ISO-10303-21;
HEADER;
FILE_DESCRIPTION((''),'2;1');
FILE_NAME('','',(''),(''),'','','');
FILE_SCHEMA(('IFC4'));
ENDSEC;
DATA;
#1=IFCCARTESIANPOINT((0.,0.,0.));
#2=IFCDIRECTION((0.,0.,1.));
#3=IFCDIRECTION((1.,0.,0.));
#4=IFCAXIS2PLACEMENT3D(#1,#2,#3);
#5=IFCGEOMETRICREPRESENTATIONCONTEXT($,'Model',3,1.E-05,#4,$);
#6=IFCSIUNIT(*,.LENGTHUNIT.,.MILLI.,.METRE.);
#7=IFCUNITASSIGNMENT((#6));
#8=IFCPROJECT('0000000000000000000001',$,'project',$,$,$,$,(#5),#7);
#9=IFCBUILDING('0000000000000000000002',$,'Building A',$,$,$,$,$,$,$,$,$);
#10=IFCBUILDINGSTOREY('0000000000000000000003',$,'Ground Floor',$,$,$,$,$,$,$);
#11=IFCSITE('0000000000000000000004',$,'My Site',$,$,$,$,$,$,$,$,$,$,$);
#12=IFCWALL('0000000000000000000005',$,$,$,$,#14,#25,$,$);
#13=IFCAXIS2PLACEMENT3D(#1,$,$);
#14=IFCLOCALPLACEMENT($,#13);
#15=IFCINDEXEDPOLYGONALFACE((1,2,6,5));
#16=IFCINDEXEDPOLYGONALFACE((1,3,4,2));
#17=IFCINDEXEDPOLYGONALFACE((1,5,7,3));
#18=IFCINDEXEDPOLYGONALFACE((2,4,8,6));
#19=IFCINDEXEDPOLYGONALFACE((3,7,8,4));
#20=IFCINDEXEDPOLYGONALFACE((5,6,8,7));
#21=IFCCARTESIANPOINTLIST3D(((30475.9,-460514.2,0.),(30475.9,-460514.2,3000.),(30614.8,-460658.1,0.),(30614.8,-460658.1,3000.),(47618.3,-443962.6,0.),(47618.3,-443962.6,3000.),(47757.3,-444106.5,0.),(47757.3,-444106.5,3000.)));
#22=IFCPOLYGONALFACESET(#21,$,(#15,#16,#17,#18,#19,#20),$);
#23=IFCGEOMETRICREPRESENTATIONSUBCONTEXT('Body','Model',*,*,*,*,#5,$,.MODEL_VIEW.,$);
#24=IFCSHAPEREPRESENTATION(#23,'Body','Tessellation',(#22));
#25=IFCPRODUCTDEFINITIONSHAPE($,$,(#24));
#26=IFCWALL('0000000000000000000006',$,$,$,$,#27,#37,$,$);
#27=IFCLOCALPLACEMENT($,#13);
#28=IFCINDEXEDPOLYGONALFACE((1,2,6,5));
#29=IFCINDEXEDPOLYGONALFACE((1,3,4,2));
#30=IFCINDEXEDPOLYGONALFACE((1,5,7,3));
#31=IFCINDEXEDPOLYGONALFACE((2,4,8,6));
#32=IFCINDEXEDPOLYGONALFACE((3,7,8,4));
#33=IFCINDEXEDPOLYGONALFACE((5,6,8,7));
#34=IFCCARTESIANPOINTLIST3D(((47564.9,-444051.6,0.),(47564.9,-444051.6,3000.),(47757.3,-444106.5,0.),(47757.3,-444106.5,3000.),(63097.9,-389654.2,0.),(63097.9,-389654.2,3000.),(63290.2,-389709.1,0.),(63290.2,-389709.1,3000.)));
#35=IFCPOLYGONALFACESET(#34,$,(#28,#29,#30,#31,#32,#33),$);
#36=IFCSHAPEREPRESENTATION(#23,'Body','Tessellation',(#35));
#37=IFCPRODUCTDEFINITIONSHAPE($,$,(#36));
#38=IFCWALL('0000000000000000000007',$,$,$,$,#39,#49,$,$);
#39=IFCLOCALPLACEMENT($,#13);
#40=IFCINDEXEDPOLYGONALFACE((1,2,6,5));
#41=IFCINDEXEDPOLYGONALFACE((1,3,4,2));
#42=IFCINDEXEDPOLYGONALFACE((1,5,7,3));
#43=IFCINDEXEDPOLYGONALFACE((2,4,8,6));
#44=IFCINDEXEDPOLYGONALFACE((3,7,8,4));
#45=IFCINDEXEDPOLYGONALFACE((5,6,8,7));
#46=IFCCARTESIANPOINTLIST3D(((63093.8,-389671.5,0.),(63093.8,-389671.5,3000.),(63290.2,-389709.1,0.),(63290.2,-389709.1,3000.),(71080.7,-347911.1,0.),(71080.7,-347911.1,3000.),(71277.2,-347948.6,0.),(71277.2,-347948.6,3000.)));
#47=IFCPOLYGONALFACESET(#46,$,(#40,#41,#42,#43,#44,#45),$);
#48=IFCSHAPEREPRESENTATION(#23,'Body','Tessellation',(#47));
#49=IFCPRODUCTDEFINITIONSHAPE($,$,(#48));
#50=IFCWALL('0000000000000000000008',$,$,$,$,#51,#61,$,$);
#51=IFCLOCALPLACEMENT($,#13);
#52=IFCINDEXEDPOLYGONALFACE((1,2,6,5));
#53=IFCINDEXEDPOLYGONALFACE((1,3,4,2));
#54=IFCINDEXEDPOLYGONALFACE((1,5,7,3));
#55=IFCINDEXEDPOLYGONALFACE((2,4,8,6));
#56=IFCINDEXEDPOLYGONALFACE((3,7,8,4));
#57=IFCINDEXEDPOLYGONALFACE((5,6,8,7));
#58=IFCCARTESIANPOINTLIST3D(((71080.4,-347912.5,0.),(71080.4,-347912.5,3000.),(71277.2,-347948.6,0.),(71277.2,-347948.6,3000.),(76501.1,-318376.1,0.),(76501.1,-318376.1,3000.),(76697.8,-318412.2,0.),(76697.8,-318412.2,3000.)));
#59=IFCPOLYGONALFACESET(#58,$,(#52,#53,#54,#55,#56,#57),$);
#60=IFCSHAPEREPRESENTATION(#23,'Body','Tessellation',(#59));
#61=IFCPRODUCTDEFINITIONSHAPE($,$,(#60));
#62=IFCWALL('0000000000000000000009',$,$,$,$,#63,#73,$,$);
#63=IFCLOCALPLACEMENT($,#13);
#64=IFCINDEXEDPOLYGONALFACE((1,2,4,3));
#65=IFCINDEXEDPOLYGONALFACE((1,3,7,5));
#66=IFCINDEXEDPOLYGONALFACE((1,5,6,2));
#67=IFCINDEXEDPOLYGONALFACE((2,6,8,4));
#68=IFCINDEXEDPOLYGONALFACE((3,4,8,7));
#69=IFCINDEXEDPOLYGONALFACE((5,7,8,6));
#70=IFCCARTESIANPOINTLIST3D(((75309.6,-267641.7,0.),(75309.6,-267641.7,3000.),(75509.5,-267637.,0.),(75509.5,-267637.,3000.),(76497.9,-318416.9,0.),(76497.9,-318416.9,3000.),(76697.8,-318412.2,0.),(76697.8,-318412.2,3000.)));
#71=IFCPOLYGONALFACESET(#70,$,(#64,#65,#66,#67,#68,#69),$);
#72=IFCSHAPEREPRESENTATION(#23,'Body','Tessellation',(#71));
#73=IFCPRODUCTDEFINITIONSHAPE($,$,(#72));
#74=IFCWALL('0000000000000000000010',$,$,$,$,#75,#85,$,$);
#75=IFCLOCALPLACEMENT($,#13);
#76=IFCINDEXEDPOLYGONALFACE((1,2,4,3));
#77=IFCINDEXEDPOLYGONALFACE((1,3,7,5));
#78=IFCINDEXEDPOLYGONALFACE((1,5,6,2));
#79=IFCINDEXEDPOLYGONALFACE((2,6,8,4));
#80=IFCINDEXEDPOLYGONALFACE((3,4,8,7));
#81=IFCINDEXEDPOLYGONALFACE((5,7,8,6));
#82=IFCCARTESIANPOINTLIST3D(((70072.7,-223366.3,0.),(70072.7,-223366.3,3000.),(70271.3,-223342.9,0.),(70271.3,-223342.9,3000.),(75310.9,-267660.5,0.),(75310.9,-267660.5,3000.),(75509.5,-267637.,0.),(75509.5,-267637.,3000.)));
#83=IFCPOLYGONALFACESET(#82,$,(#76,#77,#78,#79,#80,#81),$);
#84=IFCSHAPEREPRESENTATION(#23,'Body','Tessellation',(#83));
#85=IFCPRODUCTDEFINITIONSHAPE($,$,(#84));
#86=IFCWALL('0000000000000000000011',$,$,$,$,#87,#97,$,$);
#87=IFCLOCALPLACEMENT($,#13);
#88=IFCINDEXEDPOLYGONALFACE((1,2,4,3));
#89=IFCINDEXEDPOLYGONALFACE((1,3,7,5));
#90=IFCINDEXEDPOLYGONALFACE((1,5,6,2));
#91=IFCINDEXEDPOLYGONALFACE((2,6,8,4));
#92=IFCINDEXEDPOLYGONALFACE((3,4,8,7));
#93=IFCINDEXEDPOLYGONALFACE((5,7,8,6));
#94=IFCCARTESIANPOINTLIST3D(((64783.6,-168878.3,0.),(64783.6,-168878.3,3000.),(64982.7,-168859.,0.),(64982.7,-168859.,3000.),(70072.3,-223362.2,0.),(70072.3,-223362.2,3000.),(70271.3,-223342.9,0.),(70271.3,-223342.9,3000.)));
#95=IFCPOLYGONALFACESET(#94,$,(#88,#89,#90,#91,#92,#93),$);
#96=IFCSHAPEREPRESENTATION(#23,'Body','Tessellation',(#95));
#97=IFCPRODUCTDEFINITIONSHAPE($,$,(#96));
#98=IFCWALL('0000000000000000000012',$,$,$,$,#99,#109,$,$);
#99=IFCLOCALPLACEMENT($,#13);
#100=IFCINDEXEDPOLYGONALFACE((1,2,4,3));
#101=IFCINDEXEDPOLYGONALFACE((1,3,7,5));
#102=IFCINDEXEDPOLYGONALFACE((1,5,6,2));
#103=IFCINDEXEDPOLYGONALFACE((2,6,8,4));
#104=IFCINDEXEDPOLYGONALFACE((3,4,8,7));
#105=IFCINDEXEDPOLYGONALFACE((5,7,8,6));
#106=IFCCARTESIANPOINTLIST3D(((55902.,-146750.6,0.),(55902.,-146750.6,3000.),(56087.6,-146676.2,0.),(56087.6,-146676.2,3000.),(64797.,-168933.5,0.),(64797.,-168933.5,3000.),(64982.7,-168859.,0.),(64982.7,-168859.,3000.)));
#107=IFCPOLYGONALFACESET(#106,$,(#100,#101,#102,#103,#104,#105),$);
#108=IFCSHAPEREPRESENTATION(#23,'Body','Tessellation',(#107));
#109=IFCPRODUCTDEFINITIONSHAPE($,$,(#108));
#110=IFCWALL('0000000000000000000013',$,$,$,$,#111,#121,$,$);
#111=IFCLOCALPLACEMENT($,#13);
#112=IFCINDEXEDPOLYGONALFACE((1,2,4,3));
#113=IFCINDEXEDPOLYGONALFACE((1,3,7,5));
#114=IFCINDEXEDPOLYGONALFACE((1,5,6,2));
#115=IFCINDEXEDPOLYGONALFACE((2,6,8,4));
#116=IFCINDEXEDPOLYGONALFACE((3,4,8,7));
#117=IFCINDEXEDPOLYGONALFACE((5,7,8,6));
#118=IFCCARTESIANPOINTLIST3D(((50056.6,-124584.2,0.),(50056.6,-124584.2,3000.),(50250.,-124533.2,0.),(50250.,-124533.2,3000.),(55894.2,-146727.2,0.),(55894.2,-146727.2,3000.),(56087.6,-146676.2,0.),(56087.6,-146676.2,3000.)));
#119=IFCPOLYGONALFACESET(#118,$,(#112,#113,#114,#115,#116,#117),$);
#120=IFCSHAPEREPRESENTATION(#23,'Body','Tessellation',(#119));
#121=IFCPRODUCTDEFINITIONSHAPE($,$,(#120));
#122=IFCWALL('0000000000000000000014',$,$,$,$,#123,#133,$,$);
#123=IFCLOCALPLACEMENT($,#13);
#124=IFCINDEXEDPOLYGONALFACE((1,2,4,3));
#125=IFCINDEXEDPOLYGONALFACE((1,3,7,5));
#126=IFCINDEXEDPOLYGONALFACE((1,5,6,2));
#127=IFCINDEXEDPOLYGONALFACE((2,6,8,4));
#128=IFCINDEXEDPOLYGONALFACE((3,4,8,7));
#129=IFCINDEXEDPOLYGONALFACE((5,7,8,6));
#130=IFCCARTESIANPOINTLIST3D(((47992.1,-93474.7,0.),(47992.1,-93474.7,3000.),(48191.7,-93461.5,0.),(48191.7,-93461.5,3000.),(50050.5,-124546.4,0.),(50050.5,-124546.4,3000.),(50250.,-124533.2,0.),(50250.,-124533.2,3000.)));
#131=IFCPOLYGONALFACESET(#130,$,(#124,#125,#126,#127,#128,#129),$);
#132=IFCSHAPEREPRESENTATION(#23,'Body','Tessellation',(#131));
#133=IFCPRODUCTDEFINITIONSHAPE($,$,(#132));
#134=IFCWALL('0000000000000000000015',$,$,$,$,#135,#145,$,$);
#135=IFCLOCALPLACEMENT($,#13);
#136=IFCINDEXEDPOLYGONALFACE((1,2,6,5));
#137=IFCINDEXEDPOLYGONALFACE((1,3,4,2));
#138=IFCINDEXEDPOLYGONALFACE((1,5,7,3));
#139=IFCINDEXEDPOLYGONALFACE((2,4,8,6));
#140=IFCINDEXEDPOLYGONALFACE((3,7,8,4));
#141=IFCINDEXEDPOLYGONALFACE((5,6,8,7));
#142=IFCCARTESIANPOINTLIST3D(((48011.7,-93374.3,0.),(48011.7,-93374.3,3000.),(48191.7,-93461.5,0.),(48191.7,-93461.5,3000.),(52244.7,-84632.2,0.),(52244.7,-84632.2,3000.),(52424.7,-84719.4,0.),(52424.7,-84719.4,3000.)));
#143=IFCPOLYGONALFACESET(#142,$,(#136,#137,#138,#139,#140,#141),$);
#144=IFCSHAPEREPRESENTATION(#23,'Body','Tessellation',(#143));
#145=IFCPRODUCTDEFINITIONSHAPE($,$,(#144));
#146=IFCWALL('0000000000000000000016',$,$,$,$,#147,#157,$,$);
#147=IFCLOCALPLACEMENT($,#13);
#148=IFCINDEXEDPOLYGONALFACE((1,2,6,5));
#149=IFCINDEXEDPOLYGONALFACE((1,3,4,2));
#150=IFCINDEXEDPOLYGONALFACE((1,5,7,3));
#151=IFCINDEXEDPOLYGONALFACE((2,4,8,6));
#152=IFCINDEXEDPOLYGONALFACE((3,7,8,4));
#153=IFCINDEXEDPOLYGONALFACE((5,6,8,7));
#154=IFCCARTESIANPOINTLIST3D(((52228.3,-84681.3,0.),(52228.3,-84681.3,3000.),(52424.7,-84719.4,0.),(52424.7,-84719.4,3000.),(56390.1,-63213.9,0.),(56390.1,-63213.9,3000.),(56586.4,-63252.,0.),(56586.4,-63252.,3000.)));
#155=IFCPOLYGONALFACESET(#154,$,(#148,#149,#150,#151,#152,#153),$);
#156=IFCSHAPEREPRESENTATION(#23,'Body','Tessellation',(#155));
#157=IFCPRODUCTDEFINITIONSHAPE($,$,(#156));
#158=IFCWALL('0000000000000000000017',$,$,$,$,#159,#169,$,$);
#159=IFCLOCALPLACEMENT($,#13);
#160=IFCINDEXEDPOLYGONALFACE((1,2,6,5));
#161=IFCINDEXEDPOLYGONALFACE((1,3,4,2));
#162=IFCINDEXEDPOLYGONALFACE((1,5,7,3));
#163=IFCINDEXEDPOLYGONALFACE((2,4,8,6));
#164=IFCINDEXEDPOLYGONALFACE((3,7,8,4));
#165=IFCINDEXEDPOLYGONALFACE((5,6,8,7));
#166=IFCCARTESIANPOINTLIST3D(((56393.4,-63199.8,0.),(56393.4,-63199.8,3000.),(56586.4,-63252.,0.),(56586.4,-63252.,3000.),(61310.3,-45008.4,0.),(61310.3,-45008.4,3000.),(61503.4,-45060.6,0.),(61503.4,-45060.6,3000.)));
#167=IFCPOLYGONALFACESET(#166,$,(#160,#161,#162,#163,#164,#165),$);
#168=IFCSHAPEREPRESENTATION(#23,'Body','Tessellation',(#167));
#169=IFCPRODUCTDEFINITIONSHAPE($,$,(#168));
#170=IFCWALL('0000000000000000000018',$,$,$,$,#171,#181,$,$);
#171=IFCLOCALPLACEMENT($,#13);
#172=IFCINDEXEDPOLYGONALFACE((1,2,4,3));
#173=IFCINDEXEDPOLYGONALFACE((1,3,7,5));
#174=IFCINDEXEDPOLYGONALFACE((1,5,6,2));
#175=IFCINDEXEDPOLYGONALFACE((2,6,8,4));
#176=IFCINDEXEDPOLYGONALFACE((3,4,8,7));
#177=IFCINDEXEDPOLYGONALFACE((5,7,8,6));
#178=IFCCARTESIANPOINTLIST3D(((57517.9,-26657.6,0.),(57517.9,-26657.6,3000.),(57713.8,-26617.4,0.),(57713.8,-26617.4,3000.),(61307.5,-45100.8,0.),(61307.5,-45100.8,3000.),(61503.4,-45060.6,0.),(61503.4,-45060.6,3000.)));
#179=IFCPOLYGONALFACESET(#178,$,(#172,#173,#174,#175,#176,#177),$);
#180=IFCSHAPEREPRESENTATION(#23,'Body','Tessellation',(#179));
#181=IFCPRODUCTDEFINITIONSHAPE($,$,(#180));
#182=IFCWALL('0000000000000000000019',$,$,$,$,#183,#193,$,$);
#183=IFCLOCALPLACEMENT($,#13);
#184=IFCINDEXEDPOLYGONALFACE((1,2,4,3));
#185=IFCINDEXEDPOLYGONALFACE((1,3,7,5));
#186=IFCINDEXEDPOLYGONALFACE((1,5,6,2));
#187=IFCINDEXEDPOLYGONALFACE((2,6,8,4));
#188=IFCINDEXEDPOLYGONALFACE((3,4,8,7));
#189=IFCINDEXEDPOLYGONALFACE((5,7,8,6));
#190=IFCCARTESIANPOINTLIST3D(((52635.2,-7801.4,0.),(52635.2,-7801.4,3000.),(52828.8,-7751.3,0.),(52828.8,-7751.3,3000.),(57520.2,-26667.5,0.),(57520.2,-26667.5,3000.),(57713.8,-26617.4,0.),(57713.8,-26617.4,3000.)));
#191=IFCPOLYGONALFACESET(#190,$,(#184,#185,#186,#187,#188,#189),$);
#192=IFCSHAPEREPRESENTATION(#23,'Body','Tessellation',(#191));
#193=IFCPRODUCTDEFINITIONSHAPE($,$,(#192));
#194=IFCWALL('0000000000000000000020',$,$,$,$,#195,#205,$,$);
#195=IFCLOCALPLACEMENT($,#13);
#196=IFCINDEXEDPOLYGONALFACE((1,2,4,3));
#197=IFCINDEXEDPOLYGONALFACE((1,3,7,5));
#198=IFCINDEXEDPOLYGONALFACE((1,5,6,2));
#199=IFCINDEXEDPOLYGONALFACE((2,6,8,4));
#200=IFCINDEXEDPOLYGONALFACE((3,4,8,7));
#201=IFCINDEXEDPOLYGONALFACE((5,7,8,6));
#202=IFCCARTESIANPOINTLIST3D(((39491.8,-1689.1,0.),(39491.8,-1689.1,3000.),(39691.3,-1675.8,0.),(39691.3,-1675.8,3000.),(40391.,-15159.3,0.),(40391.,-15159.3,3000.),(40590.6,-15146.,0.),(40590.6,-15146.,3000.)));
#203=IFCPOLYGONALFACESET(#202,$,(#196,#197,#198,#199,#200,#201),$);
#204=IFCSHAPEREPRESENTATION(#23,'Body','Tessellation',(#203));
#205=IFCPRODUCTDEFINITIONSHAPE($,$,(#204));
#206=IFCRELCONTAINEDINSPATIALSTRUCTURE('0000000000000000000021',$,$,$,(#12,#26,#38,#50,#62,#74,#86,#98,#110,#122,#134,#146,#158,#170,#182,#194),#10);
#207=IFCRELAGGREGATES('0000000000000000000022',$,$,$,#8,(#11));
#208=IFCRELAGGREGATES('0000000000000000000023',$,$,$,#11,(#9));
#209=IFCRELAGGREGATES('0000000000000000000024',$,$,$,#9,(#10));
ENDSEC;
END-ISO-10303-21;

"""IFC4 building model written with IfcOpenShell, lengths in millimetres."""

from ifc_helpers import new_model, si_unit, frame, origin_with_axes, place, context, subcontext, project, spatial, indexed_curve, outline, extrude, element, save


model = new_model("IFC4")

# Units and contexts
model_context = context("Model", 3, precision=1e-05, world=origin_with_axes())
body_context = subcontext(model_context, "Body", "Model", "MODEL_VIEW")
ifc_project = project(units=[si_unit("LENGTHUNIT", "METRE", prefix="MILLI")], contexts=[model_context])

# Site, building, storey
site = spatial("IfcSite", under=ifc_project, Name="My Site")
building = spatial("IfcBuilding", under=site, Name="Building A")
storey = spatial("IfcBuildingStorey", under=building, Name="Ground Floor")

# Walls
wall_1_placement = place(None, frame((30614.8, -460658.1, 0.0), z_axis=(0.0, 0.0, 1.0), x_axis=(0.719396, 0.694601, 0.0)))
element("IfcWall", 1, at=wall_1_placement, inside=storey, context=body_context, shape_type="SweptSolid", body=[
    extrude(outline(indexed_curve([(0.0, 0.0), (0.0, 200.0), (23828.9, 200.0), (23828.9, 0.0), (0.0, 0.0)], self_intersect=False)), origin_with_axes(), (0.0, 0.0, 1.0), 3000.0),
])
wall_2_placement = place(None, frame((47757.3, -444106.5, 0.0), z_axis=(0.0, 0.0, 1.0), x_axis=(0.274571, 0.961567, 0.0)))
element("IfcWall", 2, at=wall_2_placement, inside=storey, context=body_context, shape_type="SweptSolid", body=[
    extrude(outline(indexed_curve([(0.0, 0.0), (0.0, 200.0), (56571.7, 200.0), (56571.7, 0.0), (0.0, 0.0)], self_intersect=False)), origin_with_axes(), (0.0, 0.0, 1.0), 3000.0),
])
wall_3_placement = place(None, frame((63290.2, -389709.1, 0.0), z_axis=(0.0, 0.0, 1.0), x_axis=(0.187851, 0.982197, 0.0)))
element("IfcWall", 3, at=wall_3_placement, inside=storey, context=body_context, shape_type="SweptSolid", body=[
    extrude(outline(indexed_curve([(0.0, 0.0), (0.0, 200.0), (42517.4, 200.0), (42517.4, 0.0), (0.0, 0.0)], self_intersect=False)), origin_with_axes(), (0.0, 0.0, 1.0), 3000.0),
])
wall_4_placement = place(None, frame((71277.2, -347948.6, 0.0), z_axis=(0.0, 0.0, 1.0), x_axis=(0.18051, 0.983573, 0.0)))
element("IfcWall", 4, at=wall_4_placement, inside=storey, context=body_context, shape_type="SweptSolid", body=[
    extrude(outline(indexed_curve([(0.0, 0.0), (0.0, 200.0), (30029.7, 200.0), (30029.7, 0.0), (0.0, 0.0)], self_intersect=False)), origin_with_axes(), (0.0, 0.0, 1.0), 3000.0),
])
wall_5_placement = place(None, frame((76697.8, -318412.2, 0.0), z_axis=(0.0, 0.0, 1.0), x_axis=(-0.023397, 0.999726, 0.0)))
element("IfcWall", 5, at=wall_5_placement, inside=storey, context=body_context, shape_type="SweptSolid", body=[
    extrude(outline(indexed_curve([(0.0, 0.0), (0.0, 200.0), (50789.1, 200.0), (50789.1, 0.0), (0.0, 0.0)], self_intersect=False)), origin_with_axes(), (0.0, 0.0, 1.0), 3000.0),
])
wall_6_placement = place(None, frame((75509.5, -267637.0, 0.0), z_axis=(0.0, 0.0, 1.0), x_axis=(-0.11744, 0.99308, 0.0)))
element("IfcWall", 6, at=wall_6_placement, inside=storey, context=body_context, shape_type="SweptSolid", body=[
    extrude(outline(indexed_curve([(0.0, 0.0), (0.0, 200.0), (44602.8, 200.0), (44602.8, 0.0), (0.0, 0.0)], self_intersect=False)), origin_with_axes(), (0.0, 0.0, 1.0), 3000.0),
])
wall_7_placement = place(None, frame((70271.3, -223342.9, 0.0), z_axis=(0.0, 0.0, 1.0), x_axis=(-0.096615, 0.995322, 0.0)))
element("IfcWall", 7, at=wall_7_placement, inside=storey, context=body_context, shape_type="SweptSolid", body=[
    extrude(outline(indexed_curve([(0.0, 0.0), (0.0, 200.0), (54739.9, 200.0), (54739.9, 0.0), (0.0, 0.0)], self_intersect=False)), origin_with_axes(), (0.0, 0.0, 1.0), 3000.0),
])
wall_8_placement = place(None, frame((64982.7, -168859.0, 0.0), z_axis=(0.0, 0.0, 1.0), x_axis=(-0.372182, 0.92816, 0.0)))
element("IfcWall", 8, at=wall_8_placement, inside=storey, context=body_context, shape_type="SweptSolid", body=[
    extrude(outline(indexed_curve([(0.0, 0.0), (0.0, 200.0), (23899.8, 200.0), (23899.8, 0.0), (0.0, 0.0)], self_intersect=False)), origin_with_axes(), (0.0, 0.0, 1.0), 3000.0),
])
wall_9_placement = place(None, frame((56087.6, -146676.2, 0.0), z_axis=(0.0, 0.0, 1.0), x_axis=(-0.254921, 0.966962, 0.0)))
element("IfcWall", 9, at=wall_9_placement, inside=storey, context=body_context, shape_type="SweptSolid", body=[
    extrude(outline(indexed_curve([(0.0, 0.0), (0.0, 200.0), (22899.5, 200.0), (22899.5, 0.0), (0.0, 0.0)], self_intersect=False)), origin_with_axes(), (0.0, 0.0, 1.0), 3000.0),
])
wall_10_placement = place(None, frame((50250.0, -124533.2, 0.0), z_axis=(0.0, 0.0, 1.0), x_axis=(-0.066099, 0.997813, 0.0)))
element("IfcWall", 10, at=wall_10_placement, inside=storey, context=body_context, shape_type="SweptSolid", body=[
    extrude(outline(indexed_curve([(0.0, 0.0), (0.0, 200.0), (31139.8, 200.0), (31139.8, 0.0), (0.0, 0.0)], self_intersect=False)), origin_with_axes(), (0.0, 0.0, 1.0), 3000.0),
])
wall_11_placement = place(None, frame((48191.7, -93461.5, 0.0), z_axis=(0.0, 0.0, 1.0), x_axis=(0.435805, 0.900041, 0.0)))
element("IfcWall", 11, at=wall_11_placement, inside=storey, context=body_context, shape_type="SweptSolid", body=[
    extrude(outline(indexed_curve([(0.0, 0.0), (0.0, 200.0), (9713.0, 200.0), (9713.0, 0.0), (0.0, 0.0)], self_intersect=False)), origin_with_axes(), (0.0, 0.0, 1.0), 3000.0),
])
wall_12_placement = place(None, frame((52424.7, -84719.4, 0.0), z_axis=(0.0, 0.0, 1.0), x_axis=(0.19032, 0.981722, 0.0)))
element("IfcWall", 12, at=wall_12_placement, inside=storey, context=body_context, shape_type="SweptSolid", body=[
    extrude(outline(indexed_curve([(0.0, 0.0), (0.0, 200.0), (21867.1, 200.0), (21867.1, 0.0), (0.0, 0.0)], self_intersect=False)), origin_with_axes(), (0.0, 0.0, 1.0), 3000.0),
])
wall_13_placement = place(None, frame((56586.4, -63252.0, 0.0), z_axis=(0.0, 0.0, 1.0), x_axis=(0.260927, 0.965358, 0.0)))
element("IfcWall", 13, at=wall_13_placement, inside=storey, context=body_context, shape_type="SweptSolid", body=[
    extrude(outline(indexed_curve([(0.0, 0.0), (0.0, 200.0), (18844.2, 200.0), (18844.2, 0.0), (0.0, 0.0)], self_intersect=False)), origin_with_axes(), (0.0, 0.0, 1.0), 3000.0),
])
wall_14_placement = place(None, frame((61503.4, -45060.6, 0.0), z_axis=(0.0, 0.0, 1.0), x_axis=(-0.201271, 0.979536, 0.0)))
element("IfcWall", 14, at=wall_14_placement, inside=storey, context=body_context, shape_type="SweptSolid", body=[
    extrude(outline(indexed_curve([(0.0, 0.0), (0.0, 200.0), (18828.5, 200.0), (18828.5, 0.0), (0.0, 0.0)], self_intersect=False)), origin_with_axes(), (0.0, 0.0, 1.0), 3000.0),
])
wall_15_placement = place(None, frame((57713.8, -26617.4, 0.0), z_axis=(0.0, 0.0, 1.0), x_axis=(-0.250663, 0.968074, 0.0)))
element("IfcWall", 15, at=wall_15_placement, inside=storey, context=body_context, shape_type="SweptSolid", body=[
    extrude(outline(indexed_curve([(0.0, 0.0), (0.0, 200.0), (19488.3, 200.0), (19488.3, 0.0), (0.0, 0.0)], self_intersect=False)), origin_with_axes(), (0.0, 0.0, 1.0), 3000.0),
])
wall_16_placement = place(None, frame((39491.8, -1689.1, 0.0), z_axis=(0.0, 0.0, 1.0), x_axis=(0.06661, -0.997779, 0.0)))
element("IfcWall", 16, at=wall_16_placement, inside=storey, context=body_context, shape_type="SweptSolid", body=[
    extrude(outline(indexed_curve([(0.0, 0.0), (0.0, 200.0), (13500.2, 200.0), (13500.2, 0.0), (0.0, 0.0)], self_intersect=False)), origin_with_axes(), (0.0, 0.0, 1.0), 3000.0),
])

save(model, "model.ifc")
